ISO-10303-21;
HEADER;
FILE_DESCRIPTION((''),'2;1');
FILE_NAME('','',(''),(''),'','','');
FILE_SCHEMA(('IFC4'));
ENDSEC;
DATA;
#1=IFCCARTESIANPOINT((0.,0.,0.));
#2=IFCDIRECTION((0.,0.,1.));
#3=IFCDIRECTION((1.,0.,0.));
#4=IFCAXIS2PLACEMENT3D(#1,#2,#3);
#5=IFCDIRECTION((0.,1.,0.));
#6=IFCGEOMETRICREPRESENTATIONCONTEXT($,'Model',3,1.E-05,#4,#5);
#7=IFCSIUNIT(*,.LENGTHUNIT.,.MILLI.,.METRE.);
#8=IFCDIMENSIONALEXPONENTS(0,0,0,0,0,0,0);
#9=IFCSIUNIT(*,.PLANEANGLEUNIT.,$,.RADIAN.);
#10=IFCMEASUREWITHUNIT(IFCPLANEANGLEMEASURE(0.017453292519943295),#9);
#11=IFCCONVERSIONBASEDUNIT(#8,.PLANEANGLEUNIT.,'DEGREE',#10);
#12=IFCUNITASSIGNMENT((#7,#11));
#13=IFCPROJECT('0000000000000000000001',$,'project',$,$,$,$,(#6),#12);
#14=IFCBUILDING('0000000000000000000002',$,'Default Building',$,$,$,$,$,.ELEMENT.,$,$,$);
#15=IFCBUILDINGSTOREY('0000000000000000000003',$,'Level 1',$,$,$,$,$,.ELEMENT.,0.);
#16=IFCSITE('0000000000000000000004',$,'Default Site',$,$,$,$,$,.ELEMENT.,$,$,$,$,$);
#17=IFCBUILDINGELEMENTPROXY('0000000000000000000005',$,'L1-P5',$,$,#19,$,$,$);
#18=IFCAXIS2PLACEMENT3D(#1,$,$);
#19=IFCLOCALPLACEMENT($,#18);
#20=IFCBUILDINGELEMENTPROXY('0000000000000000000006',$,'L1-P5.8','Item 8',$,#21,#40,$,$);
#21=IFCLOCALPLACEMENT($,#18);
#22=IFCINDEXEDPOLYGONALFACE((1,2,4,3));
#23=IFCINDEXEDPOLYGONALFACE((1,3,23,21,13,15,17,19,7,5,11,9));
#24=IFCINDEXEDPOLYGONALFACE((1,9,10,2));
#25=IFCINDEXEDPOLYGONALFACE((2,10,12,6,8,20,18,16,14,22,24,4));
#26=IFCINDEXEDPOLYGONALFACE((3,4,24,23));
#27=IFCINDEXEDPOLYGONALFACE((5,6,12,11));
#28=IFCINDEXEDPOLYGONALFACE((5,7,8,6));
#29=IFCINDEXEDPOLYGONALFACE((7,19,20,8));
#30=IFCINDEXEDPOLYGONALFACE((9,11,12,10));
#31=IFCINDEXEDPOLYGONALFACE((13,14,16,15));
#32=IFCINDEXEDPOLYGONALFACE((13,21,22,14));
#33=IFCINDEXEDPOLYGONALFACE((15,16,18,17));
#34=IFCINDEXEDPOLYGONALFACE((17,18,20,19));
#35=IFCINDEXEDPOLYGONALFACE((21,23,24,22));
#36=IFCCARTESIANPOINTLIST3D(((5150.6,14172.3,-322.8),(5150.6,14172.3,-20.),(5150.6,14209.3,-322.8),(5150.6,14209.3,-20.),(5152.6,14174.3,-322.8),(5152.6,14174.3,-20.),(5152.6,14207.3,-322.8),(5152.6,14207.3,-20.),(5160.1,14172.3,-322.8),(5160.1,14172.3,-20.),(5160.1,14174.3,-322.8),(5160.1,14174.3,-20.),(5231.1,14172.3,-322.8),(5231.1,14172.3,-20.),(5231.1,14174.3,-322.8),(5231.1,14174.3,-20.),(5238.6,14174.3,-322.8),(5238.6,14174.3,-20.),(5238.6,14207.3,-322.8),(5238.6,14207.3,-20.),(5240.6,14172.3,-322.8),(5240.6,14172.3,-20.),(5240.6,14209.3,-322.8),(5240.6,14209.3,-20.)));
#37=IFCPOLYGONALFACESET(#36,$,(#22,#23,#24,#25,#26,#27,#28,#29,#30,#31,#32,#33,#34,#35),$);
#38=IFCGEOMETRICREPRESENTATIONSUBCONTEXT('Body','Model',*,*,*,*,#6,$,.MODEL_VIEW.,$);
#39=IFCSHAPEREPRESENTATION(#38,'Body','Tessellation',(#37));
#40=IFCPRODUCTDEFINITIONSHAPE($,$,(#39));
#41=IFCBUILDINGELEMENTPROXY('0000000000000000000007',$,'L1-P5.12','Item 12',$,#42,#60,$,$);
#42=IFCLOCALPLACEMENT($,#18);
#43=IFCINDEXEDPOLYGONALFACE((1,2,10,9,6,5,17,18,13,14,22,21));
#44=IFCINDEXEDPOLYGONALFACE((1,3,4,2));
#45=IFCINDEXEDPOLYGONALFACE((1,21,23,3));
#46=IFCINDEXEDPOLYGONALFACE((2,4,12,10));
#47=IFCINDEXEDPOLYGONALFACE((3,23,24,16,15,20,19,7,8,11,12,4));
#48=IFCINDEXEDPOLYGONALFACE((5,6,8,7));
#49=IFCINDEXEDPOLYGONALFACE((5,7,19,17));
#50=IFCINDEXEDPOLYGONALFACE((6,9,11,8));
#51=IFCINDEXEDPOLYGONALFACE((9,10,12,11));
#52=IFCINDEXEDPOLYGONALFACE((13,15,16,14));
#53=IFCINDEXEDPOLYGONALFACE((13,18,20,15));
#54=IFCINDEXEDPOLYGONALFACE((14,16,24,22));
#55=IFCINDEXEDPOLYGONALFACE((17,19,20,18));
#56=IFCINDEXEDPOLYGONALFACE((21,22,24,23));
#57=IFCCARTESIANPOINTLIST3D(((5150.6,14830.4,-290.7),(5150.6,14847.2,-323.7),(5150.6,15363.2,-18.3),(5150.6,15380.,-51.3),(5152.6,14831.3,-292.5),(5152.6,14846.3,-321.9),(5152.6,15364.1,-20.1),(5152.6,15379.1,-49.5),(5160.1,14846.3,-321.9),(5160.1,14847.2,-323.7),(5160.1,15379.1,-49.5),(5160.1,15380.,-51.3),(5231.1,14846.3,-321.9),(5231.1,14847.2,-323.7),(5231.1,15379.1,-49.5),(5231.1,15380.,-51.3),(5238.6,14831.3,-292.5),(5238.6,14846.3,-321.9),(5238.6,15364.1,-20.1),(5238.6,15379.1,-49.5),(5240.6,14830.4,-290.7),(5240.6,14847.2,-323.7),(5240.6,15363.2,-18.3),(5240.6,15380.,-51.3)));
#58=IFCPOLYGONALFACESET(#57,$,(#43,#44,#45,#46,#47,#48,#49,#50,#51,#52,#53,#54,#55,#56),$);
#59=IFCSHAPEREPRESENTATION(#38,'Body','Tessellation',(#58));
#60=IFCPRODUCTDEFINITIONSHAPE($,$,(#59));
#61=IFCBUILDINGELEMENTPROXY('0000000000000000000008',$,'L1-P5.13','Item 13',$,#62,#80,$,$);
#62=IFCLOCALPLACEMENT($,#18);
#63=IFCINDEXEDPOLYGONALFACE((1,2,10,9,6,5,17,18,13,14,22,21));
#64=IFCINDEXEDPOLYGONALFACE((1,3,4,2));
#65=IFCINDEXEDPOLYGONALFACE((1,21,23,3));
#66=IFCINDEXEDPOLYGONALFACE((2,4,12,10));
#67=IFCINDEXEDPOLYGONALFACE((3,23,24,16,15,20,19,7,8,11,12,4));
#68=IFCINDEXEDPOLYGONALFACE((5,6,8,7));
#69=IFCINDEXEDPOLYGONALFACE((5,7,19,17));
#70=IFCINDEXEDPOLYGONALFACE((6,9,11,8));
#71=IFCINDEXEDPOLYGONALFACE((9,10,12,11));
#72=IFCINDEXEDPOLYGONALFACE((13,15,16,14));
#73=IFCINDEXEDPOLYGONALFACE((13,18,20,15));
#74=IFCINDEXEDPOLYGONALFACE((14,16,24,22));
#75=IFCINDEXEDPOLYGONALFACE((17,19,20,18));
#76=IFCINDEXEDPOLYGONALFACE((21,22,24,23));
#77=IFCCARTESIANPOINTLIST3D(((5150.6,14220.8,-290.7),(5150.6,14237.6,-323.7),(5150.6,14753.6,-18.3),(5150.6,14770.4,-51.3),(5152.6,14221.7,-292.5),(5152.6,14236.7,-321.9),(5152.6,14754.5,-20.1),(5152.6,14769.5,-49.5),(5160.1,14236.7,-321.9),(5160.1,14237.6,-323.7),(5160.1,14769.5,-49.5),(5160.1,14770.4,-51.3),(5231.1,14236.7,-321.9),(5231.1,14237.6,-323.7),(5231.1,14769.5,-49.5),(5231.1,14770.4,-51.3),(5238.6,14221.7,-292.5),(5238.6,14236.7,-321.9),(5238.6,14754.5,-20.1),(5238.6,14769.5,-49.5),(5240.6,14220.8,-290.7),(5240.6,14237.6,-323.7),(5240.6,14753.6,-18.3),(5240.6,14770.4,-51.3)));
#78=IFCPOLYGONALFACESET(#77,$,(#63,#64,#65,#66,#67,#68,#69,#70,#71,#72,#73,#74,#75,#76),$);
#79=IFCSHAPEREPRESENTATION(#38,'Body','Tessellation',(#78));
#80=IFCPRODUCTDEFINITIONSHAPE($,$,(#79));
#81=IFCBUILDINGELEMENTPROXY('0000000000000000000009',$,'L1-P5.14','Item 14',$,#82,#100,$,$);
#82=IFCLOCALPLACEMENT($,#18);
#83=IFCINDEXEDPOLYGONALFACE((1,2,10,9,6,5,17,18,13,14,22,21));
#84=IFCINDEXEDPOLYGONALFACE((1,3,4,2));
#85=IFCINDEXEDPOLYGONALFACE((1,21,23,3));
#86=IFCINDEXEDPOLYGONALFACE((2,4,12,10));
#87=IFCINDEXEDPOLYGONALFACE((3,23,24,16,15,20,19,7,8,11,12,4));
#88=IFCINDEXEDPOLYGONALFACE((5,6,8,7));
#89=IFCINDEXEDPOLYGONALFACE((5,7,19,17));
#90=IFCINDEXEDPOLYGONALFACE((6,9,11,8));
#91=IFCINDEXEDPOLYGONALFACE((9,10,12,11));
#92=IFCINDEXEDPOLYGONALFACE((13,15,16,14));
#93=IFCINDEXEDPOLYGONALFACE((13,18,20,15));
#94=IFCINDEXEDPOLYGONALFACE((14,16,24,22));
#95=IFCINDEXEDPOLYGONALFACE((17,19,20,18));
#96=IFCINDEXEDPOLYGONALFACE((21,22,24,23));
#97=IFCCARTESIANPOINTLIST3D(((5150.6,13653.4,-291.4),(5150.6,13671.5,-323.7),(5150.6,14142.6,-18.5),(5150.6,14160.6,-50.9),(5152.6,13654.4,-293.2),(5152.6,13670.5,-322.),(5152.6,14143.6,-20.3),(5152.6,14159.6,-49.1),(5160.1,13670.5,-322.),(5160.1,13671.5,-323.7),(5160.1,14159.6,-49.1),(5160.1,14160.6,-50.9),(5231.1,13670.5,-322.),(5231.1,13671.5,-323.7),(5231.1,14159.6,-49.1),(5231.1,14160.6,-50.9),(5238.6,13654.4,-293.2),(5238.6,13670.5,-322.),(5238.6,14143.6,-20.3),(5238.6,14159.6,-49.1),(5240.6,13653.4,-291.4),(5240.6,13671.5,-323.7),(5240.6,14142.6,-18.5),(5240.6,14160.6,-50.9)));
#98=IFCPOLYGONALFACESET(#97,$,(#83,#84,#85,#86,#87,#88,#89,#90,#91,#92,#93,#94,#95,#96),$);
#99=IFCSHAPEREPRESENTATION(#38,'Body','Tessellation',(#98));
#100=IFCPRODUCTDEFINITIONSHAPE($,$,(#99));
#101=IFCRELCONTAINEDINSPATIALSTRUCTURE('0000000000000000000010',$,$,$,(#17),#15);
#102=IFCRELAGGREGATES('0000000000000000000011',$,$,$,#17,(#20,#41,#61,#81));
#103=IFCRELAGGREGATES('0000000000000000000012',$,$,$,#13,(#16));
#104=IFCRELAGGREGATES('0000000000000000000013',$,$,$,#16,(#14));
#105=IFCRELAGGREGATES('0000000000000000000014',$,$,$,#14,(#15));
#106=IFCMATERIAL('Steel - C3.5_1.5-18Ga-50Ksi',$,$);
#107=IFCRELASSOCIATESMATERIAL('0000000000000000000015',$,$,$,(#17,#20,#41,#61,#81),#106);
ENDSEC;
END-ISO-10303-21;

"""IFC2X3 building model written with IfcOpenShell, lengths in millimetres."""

from ifc_helpers import new_model, entity, si_unit, converted_unit, direction, frame, origin, origin_with_axes, origin_2d_with_axis, place, context, subcontext, project, spatial, c_section, extrude, material, element, aggregate, save


model = new_model("IFC2X3")

# Units and contexts
model_context = context("Model", 3, precision=1e-05, world=origin_with_axes(), true_north=direction((0.0, 1.0, 0.0)))
body_context = subcontext(model_context, "Body", "Model", "MODEL_VIEW")
ifc_project = project(units=[si_unit("LENGTHUNIT", "METRE", prefix="MILLI"), converted_unit("PLANEANGLEUNIT", "DEGREE", entity("IfcPlaneAngleMeasure", 0.017453292519943295), si_unit("PLANEANGLEUNIT", "RADIAN"), dimensions=[0, 0, 0, 0, 0, 0, 0])], contexts=[model_context])

# Site, building, storey
site = spatial("IfcSite", under=ifc_project, Name="Default Site", CompositionType="ELEMENT")
building = spatial("IfcBuilding", under=site, Name="Default Building", CompositionType="ELEMENT")
storey = spatial("IfcBuildingStorey", under=building, Name="Level 1", CompositionType="ELEMENT", Elevation=0.0)

# Shared definitions
ifc_material_1 = material(Name="Steel - C3.5_1.5-18Ga-50Ksi")

# Building element proxies
proxy_1 = element("IfcBuildingElementProxy", 1, inside=storey, material=ifc_material_1, Name="L1-P5")
proxy_2_placement = place(None, frame((5195.6, 14190.8, -322.8), z_axis=(0.0, 0.0, 1.0), x_axis=(0.0, -37.0, 0.0)))
proxy_2 = element("IfcBuildingElementProxy", 2, at=proxy_2_placement, material=ifc_material_1, Name="L1-P5.8", Description="Item 8", context=body_context, shape_type="SweptSolid", body=[
    extrude(c_section(Depth=90.0, Width=37.0, WallThickness=2.0, Girth=9.5, at=origin_2d_with_axis()), origin(), (0.0, 0.0, 1.0), 302.8),
])
proxy_3_placement = place(None, frame((5195.6, 15371.6, -34.8), z_axis=(0.0, -0.89, -0.455), x_axis=(0.0, 16.852, -32.94)))
proxy_3 = element("IfcBuildingElementProxy", 3, at=proxy_3_placement, material=ifc_material_1, Name="L1-P5.12", Description="Item 12", context=body_context, shape_type="SweptSolid", body=[
    extrude(c_section(Depth=90.0, Width=37.0, WallThickness=2.0, Girth=9.5, at=origin_2d_with_axis()), origin(), (0.0, 0.0, 1.0), 598.4),
])
proxy_4_placement = place(None, frame((5195.6, 14762.0, -34.8), z_axis=(0.0, -0.89, -0.455), x_axis=(0.0, 16.852, -32.94)))
proxy_4 = element("IfcBuildingElementProxy", 4, at=proxy_4_placement, material=ifc_material_1, Name="L1-P5.13", Description="Item 13", context=body_context, shape_type="SweptSolid", body=[
    extrude(c_section(Depth=90.0, Width=37.0, WallThickness=2.0, Girth=9.5, at=origin_2d_with_axis()), origin(), (0.0, 0.0, 1.0), 598.4),
])
proxy_5_placement = place(None, frame((5195.6, 14151.6, -34.7), z_axis=(0.0, -0.873, -0.487), x_axis=(0.0, 18.021, -32.315)))
proxy_5 = element("IfcBuildingElementProxy", 5, at=proxy_5_placement, material=ifc_material_1, Name="L1-P5.14", Description="Item 14", context=body_context, shape_type="SweptSolid", body=[
    extrude(c_section(Depth=90.0, Width=37.0, WallThickness=2.0, Girth=9.5, at=origin_2d_with_axis()), origin(), (0.0, 0.0, 1.0), 560.1),
])
aggregate(proxy_1, [proxy_2, proxy_3, proxy_4, proxy_5])

save(model, "model.ifc")
